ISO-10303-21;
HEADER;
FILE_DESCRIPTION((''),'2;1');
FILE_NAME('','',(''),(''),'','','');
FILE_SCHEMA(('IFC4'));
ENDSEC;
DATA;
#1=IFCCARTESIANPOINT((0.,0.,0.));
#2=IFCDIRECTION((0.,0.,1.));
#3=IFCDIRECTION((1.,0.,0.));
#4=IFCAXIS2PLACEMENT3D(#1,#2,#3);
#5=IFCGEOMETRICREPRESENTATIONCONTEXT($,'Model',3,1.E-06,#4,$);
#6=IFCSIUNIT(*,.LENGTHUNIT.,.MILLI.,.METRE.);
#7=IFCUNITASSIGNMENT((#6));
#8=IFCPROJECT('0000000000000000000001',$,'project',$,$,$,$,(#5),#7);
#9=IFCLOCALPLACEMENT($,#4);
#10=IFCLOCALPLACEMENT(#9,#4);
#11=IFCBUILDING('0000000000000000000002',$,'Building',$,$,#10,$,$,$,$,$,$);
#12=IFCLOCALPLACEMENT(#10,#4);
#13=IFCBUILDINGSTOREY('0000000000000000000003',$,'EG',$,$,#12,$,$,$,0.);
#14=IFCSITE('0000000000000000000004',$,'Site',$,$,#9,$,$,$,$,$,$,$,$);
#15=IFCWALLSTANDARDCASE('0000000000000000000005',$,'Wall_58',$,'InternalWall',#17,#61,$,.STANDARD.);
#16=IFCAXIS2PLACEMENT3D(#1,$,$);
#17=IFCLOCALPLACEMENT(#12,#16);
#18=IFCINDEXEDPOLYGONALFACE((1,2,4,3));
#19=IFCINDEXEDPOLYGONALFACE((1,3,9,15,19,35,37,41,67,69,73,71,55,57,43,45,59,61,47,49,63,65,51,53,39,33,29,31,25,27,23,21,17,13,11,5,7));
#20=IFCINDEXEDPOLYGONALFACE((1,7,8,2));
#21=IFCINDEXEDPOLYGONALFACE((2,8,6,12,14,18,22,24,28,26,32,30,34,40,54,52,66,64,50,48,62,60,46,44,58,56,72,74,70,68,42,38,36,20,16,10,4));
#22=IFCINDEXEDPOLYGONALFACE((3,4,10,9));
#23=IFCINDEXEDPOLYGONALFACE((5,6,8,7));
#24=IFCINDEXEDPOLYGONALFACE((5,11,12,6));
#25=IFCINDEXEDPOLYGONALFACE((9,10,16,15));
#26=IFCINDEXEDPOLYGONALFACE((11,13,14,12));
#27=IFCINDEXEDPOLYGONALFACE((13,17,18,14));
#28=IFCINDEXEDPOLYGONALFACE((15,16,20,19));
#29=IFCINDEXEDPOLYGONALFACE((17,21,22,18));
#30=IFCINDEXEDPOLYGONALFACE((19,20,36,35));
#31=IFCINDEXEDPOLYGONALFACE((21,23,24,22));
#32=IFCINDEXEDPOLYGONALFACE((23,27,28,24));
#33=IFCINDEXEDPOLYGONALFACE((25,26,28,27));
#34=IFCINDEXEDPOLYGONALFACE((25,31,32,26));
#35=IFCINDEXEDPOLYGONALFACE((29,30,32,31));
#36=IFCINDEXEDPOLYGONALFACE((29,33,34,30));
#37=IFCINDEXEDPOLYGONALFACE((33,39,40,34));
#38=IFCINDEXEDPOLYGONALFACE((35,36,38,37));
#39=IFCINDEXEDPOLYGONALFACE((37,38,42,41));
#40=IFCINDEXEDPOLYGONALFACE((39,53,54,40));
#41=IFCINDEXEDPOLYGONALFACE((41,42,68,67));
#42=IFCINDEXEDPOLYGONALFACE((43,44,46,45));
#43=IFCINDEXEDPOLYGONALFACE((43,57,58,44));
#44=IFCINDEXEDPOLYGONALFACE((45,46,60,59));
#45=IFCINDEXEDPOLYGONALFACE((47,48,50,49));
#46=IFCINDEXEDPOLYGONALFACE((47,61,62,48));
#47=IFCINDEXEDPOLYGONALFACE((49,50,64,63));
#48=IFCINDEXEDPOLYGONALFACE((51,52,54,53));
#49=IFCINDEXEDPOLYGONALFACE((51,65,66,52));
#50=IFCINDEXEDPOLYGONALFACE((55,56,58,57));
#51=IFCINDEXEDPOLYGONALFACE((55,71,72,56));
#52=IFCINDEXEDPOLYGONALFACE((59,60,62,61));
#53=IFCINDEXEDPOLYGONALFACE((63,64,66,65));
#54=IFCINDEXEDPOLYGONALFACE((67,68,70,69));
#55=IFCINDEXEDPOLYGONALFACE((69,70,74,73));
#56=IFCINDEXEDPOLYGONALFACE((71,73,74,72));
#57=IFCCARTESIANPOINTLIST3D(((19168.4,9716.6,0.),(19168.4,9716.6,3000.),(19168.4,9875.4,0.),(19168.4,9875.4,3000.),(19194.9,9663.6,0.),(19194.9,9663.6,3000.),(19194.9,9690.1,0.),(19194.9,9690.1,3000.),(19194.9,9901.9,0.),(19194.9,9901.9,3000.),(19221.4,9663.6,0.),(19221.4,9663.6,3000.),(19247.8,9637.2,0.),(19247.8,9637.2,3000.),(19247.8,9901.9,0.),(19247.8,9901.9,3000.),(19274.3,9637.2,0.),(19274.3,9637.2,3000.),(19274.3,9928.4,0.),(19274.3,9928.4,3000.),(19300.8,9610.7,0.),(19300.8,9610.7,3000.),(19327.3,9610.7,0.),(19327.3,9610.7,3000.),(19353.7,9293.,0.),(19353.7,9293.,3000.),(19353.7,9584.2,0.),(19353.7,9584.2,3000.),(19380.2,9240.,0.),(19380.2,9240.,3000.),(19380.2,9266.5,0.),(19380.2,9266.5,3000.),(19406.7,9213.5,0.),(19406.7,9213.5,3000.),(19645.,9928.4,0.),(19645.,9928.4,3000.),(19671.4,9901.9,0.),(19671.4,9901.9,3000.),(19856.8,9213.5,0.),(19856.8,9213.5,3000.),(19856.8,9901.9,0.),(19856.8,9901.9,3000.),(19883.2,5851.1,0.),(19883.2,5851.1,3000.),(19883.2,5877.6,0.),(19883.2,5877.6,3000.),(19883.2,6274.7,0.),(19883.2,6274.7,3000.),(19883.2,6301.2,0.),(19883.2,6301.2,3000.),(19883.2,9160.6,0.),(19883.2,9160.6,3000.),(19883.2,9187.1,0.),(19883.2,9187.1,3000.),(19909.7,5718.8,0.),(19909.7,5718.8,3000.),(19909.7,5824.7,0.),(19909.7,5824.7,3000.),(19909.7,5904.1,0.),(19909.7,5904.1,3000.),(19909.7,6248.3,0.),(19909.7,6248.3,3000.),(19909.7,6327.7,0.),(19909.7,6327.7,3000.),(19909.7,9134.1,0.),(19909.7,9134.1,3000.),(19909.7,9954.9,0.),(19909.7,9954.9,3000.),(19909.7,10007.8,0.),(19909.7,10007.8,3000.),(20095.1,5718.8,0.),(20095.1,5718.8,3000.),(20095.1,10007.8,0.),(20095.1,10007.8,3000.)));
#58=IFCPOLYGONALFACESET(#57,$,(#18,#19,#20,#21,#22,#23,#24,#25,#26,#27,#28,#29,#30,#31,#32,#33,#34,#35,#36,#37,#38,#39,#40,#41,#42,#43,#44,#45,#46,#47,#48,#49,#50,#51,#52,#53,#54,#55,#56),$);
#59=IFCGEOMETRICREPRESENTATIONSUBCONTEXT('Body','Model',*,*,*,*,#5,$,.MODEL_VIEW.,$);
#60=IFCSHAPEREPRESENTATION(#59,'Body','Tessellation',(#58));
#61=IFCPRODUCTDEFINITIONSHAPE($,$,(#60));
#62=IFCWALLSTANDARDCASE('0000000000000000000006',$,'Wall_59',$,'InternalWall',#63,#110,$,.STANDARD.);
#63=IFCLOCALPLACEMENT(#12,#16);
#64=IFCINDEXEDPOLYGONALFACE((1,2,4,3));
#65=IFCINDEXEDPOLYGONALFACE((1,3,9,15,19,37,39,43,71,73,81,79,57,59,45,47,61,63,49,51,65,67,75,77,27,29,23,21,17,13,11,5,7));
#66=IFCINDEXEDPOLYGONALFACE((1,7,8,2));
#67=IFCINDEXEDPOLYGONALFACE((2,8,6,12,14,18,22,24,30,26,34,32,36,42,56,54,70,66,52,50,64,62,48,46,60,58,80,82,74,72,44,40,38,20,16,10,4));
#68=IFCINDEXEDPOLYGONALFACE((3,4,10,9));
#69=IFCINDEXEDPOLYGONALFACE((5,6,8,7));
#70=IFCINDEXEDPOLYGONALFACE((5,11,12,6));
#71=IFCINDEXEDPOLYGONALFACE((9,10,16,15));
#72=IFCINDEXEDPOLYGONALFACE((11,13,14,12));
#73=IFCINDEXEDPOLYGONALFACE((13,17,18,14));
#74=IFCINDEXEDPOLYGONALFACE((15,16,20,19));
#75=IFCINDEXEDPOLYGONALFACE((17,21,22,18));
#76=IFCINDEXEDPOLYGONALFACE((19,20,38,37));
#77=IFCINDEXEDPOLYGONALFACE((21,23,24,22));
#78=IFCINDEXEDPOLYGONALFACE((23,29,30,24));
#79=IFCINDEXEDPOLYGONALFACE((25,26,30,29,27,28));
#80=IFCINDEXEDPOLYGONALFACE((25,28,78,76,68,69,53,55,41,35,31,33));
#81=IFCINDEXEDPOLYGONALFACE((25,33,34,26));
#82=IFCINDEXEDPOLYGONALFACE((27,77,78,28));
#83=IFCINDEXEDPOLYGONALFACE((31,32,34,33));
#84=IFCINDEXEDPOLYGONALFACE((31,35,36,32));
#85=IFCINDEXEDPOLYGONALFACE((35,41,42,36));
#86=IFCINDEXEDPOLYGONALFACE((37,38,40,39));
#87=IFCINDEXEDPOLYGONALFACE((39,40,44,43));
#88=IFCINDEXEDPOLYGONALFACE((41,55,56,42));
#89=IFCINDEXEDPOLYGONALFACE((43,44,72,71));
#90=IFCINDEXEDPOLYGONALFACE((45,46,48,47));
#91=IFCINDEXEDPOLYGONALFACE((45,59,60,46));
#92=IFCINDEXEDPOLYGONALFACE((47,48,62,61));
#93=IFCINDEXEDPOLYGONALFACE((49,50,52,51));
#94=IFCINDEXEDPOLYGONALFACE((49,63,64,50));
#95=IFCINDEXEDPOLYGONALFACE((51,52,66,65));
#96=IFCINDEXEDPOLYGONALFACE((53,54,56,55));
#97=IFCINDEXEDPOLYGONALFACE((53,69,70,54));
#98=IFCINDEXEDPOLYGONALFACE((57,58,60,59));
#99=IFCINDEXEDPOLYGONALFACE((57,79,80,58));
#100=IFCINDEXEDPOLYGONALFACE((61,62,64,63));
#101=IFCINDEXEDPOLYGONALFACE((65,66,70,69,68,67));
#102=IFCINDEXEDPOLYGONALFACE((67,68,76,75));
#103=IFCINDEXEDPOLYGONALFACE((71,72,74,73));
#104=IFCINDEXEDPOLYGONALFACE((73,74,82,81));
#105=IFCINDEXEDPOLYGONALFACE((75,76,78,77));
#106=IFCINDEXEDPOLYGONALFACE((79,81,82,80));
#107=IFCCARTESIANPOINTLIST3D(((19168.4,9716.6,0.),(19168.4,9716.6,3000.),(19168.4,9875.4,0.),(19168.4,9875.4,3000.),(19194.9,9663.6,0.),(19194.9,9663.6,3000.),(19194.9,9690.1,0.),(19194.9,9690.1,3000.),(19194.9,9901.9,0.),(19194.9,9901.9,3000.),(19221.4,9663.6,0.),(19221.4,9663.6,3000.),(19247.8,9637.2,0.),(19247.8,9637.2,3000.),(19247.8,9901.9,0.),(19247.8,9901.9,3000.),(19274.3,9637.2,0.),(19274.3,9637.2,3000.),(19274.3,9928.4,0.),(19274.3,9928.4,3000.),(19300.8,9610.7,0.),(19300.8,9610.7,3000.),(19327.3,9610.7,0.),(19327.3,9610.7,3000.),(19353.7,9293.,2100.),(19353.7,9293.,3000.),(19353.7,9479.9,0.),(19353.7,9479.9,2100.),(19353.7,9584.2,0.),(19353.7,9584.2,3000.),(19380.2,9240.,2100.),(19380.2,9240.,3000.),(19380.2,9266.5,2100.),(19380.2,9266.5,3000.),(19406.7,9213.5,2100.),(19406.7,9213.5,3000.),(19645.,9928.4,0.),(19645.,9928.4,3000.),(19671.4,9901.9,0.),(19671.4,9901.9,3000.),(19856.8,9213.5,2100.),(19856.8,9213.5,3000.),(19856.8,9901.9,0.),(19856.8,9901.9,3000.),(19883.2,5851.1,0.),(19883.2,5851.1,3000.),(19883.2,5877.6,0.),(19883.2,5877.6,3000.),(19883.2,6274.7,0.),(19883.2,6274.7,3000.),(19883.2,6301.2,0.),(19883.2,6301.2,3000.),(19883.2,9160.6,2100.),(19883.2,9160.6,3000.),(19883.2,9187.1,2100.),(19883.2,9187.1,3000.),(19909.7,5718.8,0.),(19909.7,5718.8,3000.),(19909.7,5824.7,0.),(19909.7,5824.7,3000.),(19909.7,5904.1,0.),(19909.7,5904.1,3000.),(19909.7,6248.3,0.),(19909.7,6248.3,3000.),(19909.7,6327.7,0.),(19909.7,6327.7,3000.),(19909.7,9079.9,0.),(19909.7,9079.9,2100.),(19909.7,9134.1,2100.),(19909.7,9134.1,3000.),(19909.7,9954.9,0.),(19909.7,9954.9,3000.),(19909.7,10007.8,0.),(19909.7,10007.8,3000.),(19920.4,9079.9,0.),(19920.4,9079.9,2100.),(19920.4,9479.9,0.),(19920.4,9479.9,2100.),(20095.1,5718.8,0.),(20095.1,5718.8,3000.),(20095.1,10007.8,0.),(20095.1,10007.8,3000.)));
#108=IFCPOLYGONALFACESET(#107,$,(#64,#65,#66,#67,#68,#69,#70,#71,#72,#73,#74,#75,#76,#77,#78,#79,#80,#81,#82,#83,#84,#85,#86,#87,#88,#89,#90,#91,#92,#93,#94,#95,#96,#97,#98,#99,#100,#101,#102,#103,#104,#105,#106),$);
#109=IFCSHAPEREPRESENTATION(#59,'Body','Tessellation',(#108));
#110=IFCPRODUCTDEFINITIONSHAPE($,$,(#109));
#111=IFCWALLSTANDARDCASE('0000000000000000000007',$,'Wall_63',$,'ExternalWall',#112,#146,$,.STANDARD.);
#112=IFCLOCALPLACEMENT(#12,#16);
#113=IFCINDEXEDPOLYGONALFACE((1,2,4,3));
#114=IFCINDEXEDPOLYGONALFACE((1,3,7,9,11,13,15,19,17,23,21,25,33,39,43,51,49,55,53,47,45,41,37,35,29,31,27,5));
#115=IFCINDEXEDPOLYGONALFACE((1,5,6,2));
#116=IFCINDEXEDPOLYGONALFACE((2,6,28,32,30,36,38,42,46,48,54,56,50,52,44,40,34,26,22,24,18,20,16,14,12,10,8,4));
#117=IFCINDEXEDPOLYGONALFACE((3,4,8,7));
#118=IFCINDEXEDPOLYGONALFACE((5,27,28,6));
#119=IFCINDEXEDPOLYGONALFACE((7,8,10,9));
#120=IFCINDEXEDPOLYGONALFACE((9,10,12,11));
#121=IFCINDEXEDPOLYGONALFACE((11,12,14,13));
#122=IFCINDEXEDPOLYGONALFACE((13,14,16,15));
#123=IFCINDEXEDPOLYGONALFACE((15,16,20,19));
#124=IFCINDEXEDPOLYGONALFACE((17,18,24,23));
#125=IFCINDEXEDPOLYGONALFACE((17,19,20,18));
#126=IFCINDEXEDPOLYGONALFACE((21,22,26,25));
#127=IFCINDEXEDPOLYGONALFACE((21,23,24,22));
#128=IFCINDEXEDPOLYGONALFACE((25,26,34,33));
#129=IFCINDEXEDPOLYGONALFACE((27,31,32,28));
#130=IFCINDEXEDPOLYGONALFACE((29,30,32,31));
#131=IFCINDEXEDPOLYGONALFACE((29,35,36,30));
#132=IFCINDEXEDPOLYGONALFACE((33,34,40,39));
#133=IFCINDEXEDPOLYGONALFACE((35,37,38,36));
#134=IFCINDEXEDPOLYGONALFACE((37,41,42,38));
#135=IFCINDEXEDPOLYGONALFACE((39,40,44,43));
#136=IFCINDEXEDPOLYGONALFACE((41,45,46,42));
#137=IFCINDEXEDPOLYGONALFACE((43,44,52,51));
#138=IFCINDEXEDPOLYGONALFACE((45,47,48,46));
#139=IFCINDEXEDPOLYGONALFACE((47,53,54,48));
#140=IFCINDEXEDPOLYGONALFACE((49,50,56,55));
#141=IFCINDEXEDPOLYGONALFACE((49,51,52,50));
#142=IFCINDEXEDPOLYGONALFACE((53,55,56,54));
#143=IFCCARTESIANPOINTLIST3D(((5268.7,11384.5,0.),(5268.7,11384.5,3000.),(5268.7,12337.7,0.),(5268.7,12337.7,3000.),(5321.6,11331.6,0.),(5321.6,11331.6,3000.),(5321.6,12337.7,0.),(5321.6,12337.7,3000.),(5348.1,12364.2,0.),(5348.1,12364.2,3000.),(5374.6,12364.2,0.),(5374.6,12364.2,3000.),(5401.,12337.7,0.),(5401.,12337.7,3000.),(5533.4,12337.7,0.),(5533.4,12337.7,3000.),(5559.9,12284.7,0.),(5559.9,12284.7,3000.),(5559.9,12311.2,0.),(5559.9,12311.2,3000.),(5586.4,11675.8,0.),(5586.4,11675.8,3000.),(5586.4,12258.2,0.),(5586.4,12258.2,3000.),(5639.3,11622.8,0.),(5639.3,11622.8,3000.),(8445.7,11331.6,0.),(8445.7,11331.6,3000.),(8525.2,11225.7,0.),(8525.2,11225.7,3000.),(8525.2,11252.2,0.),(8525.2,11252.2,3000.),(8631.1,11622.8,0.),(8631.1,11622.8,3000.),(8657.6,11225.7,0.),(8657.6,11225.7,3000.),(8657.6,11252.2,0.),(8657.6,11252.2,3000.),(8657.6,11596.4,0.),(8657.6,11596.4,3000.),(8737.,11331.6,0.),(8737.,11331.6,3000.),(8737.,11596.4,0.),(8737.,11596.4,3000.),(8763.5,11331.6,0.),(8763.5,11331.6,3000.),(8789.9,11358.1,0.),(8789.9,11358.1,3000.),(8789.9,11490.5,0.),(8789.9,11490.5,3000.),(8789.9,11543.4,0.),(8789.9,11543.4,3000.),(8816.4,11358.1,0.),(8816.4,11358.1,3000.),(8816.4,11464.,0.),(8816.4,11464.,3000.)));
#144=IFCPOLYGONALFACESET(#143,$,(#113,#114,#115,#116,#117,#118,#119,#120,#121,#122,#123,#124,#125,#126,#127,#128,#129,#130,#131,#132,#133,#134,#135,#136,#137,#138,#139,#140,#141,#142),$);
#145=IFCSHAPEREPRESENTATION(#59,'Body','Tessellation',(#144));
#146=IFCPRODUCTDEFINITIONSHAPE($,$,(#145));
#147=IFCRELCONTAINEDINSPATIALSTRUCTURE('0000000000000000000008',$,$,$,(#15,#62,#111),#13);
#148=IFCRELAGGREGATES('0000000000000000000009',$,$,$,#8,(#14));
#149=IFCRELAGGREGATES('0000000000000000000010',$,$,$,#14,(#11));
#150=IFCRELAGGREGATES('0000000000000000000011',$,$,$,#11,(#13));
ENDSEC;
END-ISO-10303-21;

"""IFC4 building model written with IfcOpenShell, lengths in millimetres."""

from ifc_helpers import new_model, si_unit, frame, origin_with_axes, place, context, subcontext, project, spatial, polyline, rectangle, outline, extrude, element, save


model = new_model("IFC4")

# Units and contexts
model_context = context("Model", 3, precision=1e-06, world=origin_with_axes())
body_context = subcontext(model_context, "Body", "Model", "MODEL_VIEW")
ifc_project = project(units=[si_unit("LENGTHUNIT", "METRE", prefix="MILLI")], contexts=[model_context])

# Site, building, storey
site_placement = place(None, origin_with_axes())
site = spatial("IfcSite", under=ifc_project, at=site_placement, Name="Site")
building_placement = place(site_placement, origin_with_axes())
building = spatial("IfcBuilding", under=site, at=building_placement, Name="Building")
storey_placement = place(building_placement, origin_with_axes())
storey = spatial("IfcBuildingStorey", under=building, at=storey_placement, Name="EG", Elevation=0.0)

# Wall
wall_1_placement = place(storey_placement, origin_with_axes())
element("IfcWallStandardCase", 1, at=wall_1_placement, inside=storey, Name="Wall_58", ObjectType="InternalWall", PredefinedType="STANDARD", context=body_context, shape_type="SweptSolid", body=[
    extrude(outline(polyline([(19909.7, 5718.8, 0.0), (19909.7, 5824.7, 0.0), (19883.2, 5851.1, 0.0), (19883.2, 5877.6, 0.0), (19909.7, 5904.1, 0.0), (19909.7, 6248.3, 0.0), (19883.2, 6274.7, 0.0), (19883.2, 6301.2, 0.0), (19909.7, 6327.7, 0.0), (19909.7, 9134.1, 0.0), (19883.2, 9160.6, 0.0), (19883.2, 9187.1, 0.0), (19856.8, 9213.5, 0.0), (19406.7, 9213.5, 0.0), (19380.2, 9240.0, 0.0), (19380.2, 9266.5, 0.0), (19353.7, 9293.0, 0.0), (19353.7, 9584.2, 0.0), (19327.3, 9610.7, 0.0), (19300.8, 9610.7, 0.0), (19274.3, 9637.2, 0.0), (19247.8, 9637.2, 0.0), (19221.4, 9663.6, 0.0), (19194.9, 9663.6, 0.0), (19194.9, 9690.1, 0.0), (19168.4, 9716.6, 0.0), (19168.4, 9875.4, 0.0), (19194.9, 9901.9, 0.0), (19247.8, 9901.9, 0.0), (19274.3, 9928.4, 0.0), (19645.0, 9928.4, 0.0), (19671.4, 9901.9, 0.0), (19856.8, 9901.9, 0.0), (19909.7, 9954.9, 0.0), (19909.7, 10007.8, 0.0), (20095.1, 10007.8, 0.0), (20095.1, 5718.8, 0.0), (19909.7, 5718.8, 0.0)])), origin_with_axes(), (0.0, 0.0, 1.0), 3000.0),
])

# Wall, opening
wall_2_placement = place(storey_placement, origin_with_axes())
wall_2 = element("IfcWallStandardCase", 2, at=wall_2_placement, inside=storey, Name="Wall_59", ObjectType="InternalWall", PredefinedType="STANDARD", context=body_context, shape_type="SweptSolid", body=[
    extrude(outline(polyline([(19909.7, 5718.8, 0.0), (19909.7, 5824.7, 0.0), (19883.2, 5851.1, 0.0), (19883.2, 5877.6, 0.0), (19909.7, 5904.1, 0.0), (19909.7, 6248.3, 0.0), (19883.2, 6274.7, 0.0), (19883.2, 6301.2, 0.0), (19909.7, 6327.7, 0.0), (19909.7, 9134.1, 0.0), (19883.2, 9160.6, 0.0), (19883.2, 9187.1, 0.0), (19856.8, 9213.5, 0.0), (19406.7, 9213.5, 0.0), (19380.2, 9240.0, 0.0), (19380.2, 9266.5, 0.0), (19353.7, 9293.0, 0.0), (19353.7, 9584.2, 0.0), (19327.3, 9610.7, 0.0), (19300.8, 9610.7, 0.0), (19274.3, 9637.2, 0.0), (19247.8, 9637.2, 0.0), (19221.4, 9663.6, 0.0), (19194.9, 9663.6, 0.0), (19194.9, 9690.1, 0.0), (19168.4, 9716.6, 0.0), (19168.4, 9875.4, 0.0), (19194.9, 9901.9, 0.0), (19247.8, 9901.9, 0.0), (19274.3, 9928.4, 0.0), (19645.0, 9928.4, 0.0), (19671.4, 9901.9, 0.0), (19856.8, 9901.9, 0.0), (19909.7, 9954.9, 0.0), (19909.7, 10007.8, 0.0), (20095.1, 10007.8, 0.0), (20095.1, 5718.8, 0.0), (19909.7, 5718.8, 0.0)])), origin_with_axes(), (0.0, 0.0, 1.0), 3000.0),
])
opening_1_placement = place(wall_2_placement, origin_with_axes())
element("IfcOpeningElement", 3, at=opening_1_placement, inside=storey, cuts=wall_2, context=body_context, shape_type="SweptSolid", body=[
    extrude(rectangle(XDim=1048.4, YDim=400.0), frame((19396.2, 9279.9, 0.0), z_axis=(0.0, 0.0, 1.0), x_axis=(1.0, 0.0, 0.0)), (0.0, 0.0, 1.0), 2100.0),
])

# Wall
wall_3_placement = place(storey_placement, origin_with_axes())
element("IfcWallStandardCase", 4, at=wall_3_placement, inside=storey, Name="Wall_63", ObjectType="ExternalWall", PredefinedType="STANDARD", context=body_context, shape_type="SweptSolid", body=[
    extrude(outline(polyline([(8525.2, 11225.7, 0.0), (8525.2, 11252.2, 0.0), (8445.7, 11331.6, 0.0), (5321.6, 11331.6, 0.0), (5268.7, 11384.5, 0.0), (5268.7, 12337.7, 0.0), (5321.6, 12337.7, 0.0), (5348.1, 12364.2, 0.0), (5374.6, 12364.2, 0.0), (5401.0, 12337.7, 0.0), (5533.4, 12337.7, 0.0), (5559.9, 12311.2, 0.0), (5559.9, 12284.7, 0.0), (5586.4, 12258.2, 0.0), (5586.4, 11675.8, 0.0), (5639.3, 11622.8, 0.0), (8631.1, 11622.8, 0.0), (8657.6, 11596.4, 0.0), (8737.0, 11596.4, 0.0), (8789.9, 11543.4, 0.0), (8789.9, 11490.5, 0.0), (8816.4, 11464.0, 0.0), (8816.4, 11358.1, 0.0), (8789.9, 11358.1, 0.0), (8763.5, 11331.6, 0.0), (8737.0, 11331.6, 0.0), (8657.6, 11252.2, 0.0), (8657.6, 11225.7, 0.0), (8525.2, 11225.7, 0.0)])), origin_with_axes(), (0.0, 0.0, 1.0), 3000.0),
])

save(model, "model.ifc")
